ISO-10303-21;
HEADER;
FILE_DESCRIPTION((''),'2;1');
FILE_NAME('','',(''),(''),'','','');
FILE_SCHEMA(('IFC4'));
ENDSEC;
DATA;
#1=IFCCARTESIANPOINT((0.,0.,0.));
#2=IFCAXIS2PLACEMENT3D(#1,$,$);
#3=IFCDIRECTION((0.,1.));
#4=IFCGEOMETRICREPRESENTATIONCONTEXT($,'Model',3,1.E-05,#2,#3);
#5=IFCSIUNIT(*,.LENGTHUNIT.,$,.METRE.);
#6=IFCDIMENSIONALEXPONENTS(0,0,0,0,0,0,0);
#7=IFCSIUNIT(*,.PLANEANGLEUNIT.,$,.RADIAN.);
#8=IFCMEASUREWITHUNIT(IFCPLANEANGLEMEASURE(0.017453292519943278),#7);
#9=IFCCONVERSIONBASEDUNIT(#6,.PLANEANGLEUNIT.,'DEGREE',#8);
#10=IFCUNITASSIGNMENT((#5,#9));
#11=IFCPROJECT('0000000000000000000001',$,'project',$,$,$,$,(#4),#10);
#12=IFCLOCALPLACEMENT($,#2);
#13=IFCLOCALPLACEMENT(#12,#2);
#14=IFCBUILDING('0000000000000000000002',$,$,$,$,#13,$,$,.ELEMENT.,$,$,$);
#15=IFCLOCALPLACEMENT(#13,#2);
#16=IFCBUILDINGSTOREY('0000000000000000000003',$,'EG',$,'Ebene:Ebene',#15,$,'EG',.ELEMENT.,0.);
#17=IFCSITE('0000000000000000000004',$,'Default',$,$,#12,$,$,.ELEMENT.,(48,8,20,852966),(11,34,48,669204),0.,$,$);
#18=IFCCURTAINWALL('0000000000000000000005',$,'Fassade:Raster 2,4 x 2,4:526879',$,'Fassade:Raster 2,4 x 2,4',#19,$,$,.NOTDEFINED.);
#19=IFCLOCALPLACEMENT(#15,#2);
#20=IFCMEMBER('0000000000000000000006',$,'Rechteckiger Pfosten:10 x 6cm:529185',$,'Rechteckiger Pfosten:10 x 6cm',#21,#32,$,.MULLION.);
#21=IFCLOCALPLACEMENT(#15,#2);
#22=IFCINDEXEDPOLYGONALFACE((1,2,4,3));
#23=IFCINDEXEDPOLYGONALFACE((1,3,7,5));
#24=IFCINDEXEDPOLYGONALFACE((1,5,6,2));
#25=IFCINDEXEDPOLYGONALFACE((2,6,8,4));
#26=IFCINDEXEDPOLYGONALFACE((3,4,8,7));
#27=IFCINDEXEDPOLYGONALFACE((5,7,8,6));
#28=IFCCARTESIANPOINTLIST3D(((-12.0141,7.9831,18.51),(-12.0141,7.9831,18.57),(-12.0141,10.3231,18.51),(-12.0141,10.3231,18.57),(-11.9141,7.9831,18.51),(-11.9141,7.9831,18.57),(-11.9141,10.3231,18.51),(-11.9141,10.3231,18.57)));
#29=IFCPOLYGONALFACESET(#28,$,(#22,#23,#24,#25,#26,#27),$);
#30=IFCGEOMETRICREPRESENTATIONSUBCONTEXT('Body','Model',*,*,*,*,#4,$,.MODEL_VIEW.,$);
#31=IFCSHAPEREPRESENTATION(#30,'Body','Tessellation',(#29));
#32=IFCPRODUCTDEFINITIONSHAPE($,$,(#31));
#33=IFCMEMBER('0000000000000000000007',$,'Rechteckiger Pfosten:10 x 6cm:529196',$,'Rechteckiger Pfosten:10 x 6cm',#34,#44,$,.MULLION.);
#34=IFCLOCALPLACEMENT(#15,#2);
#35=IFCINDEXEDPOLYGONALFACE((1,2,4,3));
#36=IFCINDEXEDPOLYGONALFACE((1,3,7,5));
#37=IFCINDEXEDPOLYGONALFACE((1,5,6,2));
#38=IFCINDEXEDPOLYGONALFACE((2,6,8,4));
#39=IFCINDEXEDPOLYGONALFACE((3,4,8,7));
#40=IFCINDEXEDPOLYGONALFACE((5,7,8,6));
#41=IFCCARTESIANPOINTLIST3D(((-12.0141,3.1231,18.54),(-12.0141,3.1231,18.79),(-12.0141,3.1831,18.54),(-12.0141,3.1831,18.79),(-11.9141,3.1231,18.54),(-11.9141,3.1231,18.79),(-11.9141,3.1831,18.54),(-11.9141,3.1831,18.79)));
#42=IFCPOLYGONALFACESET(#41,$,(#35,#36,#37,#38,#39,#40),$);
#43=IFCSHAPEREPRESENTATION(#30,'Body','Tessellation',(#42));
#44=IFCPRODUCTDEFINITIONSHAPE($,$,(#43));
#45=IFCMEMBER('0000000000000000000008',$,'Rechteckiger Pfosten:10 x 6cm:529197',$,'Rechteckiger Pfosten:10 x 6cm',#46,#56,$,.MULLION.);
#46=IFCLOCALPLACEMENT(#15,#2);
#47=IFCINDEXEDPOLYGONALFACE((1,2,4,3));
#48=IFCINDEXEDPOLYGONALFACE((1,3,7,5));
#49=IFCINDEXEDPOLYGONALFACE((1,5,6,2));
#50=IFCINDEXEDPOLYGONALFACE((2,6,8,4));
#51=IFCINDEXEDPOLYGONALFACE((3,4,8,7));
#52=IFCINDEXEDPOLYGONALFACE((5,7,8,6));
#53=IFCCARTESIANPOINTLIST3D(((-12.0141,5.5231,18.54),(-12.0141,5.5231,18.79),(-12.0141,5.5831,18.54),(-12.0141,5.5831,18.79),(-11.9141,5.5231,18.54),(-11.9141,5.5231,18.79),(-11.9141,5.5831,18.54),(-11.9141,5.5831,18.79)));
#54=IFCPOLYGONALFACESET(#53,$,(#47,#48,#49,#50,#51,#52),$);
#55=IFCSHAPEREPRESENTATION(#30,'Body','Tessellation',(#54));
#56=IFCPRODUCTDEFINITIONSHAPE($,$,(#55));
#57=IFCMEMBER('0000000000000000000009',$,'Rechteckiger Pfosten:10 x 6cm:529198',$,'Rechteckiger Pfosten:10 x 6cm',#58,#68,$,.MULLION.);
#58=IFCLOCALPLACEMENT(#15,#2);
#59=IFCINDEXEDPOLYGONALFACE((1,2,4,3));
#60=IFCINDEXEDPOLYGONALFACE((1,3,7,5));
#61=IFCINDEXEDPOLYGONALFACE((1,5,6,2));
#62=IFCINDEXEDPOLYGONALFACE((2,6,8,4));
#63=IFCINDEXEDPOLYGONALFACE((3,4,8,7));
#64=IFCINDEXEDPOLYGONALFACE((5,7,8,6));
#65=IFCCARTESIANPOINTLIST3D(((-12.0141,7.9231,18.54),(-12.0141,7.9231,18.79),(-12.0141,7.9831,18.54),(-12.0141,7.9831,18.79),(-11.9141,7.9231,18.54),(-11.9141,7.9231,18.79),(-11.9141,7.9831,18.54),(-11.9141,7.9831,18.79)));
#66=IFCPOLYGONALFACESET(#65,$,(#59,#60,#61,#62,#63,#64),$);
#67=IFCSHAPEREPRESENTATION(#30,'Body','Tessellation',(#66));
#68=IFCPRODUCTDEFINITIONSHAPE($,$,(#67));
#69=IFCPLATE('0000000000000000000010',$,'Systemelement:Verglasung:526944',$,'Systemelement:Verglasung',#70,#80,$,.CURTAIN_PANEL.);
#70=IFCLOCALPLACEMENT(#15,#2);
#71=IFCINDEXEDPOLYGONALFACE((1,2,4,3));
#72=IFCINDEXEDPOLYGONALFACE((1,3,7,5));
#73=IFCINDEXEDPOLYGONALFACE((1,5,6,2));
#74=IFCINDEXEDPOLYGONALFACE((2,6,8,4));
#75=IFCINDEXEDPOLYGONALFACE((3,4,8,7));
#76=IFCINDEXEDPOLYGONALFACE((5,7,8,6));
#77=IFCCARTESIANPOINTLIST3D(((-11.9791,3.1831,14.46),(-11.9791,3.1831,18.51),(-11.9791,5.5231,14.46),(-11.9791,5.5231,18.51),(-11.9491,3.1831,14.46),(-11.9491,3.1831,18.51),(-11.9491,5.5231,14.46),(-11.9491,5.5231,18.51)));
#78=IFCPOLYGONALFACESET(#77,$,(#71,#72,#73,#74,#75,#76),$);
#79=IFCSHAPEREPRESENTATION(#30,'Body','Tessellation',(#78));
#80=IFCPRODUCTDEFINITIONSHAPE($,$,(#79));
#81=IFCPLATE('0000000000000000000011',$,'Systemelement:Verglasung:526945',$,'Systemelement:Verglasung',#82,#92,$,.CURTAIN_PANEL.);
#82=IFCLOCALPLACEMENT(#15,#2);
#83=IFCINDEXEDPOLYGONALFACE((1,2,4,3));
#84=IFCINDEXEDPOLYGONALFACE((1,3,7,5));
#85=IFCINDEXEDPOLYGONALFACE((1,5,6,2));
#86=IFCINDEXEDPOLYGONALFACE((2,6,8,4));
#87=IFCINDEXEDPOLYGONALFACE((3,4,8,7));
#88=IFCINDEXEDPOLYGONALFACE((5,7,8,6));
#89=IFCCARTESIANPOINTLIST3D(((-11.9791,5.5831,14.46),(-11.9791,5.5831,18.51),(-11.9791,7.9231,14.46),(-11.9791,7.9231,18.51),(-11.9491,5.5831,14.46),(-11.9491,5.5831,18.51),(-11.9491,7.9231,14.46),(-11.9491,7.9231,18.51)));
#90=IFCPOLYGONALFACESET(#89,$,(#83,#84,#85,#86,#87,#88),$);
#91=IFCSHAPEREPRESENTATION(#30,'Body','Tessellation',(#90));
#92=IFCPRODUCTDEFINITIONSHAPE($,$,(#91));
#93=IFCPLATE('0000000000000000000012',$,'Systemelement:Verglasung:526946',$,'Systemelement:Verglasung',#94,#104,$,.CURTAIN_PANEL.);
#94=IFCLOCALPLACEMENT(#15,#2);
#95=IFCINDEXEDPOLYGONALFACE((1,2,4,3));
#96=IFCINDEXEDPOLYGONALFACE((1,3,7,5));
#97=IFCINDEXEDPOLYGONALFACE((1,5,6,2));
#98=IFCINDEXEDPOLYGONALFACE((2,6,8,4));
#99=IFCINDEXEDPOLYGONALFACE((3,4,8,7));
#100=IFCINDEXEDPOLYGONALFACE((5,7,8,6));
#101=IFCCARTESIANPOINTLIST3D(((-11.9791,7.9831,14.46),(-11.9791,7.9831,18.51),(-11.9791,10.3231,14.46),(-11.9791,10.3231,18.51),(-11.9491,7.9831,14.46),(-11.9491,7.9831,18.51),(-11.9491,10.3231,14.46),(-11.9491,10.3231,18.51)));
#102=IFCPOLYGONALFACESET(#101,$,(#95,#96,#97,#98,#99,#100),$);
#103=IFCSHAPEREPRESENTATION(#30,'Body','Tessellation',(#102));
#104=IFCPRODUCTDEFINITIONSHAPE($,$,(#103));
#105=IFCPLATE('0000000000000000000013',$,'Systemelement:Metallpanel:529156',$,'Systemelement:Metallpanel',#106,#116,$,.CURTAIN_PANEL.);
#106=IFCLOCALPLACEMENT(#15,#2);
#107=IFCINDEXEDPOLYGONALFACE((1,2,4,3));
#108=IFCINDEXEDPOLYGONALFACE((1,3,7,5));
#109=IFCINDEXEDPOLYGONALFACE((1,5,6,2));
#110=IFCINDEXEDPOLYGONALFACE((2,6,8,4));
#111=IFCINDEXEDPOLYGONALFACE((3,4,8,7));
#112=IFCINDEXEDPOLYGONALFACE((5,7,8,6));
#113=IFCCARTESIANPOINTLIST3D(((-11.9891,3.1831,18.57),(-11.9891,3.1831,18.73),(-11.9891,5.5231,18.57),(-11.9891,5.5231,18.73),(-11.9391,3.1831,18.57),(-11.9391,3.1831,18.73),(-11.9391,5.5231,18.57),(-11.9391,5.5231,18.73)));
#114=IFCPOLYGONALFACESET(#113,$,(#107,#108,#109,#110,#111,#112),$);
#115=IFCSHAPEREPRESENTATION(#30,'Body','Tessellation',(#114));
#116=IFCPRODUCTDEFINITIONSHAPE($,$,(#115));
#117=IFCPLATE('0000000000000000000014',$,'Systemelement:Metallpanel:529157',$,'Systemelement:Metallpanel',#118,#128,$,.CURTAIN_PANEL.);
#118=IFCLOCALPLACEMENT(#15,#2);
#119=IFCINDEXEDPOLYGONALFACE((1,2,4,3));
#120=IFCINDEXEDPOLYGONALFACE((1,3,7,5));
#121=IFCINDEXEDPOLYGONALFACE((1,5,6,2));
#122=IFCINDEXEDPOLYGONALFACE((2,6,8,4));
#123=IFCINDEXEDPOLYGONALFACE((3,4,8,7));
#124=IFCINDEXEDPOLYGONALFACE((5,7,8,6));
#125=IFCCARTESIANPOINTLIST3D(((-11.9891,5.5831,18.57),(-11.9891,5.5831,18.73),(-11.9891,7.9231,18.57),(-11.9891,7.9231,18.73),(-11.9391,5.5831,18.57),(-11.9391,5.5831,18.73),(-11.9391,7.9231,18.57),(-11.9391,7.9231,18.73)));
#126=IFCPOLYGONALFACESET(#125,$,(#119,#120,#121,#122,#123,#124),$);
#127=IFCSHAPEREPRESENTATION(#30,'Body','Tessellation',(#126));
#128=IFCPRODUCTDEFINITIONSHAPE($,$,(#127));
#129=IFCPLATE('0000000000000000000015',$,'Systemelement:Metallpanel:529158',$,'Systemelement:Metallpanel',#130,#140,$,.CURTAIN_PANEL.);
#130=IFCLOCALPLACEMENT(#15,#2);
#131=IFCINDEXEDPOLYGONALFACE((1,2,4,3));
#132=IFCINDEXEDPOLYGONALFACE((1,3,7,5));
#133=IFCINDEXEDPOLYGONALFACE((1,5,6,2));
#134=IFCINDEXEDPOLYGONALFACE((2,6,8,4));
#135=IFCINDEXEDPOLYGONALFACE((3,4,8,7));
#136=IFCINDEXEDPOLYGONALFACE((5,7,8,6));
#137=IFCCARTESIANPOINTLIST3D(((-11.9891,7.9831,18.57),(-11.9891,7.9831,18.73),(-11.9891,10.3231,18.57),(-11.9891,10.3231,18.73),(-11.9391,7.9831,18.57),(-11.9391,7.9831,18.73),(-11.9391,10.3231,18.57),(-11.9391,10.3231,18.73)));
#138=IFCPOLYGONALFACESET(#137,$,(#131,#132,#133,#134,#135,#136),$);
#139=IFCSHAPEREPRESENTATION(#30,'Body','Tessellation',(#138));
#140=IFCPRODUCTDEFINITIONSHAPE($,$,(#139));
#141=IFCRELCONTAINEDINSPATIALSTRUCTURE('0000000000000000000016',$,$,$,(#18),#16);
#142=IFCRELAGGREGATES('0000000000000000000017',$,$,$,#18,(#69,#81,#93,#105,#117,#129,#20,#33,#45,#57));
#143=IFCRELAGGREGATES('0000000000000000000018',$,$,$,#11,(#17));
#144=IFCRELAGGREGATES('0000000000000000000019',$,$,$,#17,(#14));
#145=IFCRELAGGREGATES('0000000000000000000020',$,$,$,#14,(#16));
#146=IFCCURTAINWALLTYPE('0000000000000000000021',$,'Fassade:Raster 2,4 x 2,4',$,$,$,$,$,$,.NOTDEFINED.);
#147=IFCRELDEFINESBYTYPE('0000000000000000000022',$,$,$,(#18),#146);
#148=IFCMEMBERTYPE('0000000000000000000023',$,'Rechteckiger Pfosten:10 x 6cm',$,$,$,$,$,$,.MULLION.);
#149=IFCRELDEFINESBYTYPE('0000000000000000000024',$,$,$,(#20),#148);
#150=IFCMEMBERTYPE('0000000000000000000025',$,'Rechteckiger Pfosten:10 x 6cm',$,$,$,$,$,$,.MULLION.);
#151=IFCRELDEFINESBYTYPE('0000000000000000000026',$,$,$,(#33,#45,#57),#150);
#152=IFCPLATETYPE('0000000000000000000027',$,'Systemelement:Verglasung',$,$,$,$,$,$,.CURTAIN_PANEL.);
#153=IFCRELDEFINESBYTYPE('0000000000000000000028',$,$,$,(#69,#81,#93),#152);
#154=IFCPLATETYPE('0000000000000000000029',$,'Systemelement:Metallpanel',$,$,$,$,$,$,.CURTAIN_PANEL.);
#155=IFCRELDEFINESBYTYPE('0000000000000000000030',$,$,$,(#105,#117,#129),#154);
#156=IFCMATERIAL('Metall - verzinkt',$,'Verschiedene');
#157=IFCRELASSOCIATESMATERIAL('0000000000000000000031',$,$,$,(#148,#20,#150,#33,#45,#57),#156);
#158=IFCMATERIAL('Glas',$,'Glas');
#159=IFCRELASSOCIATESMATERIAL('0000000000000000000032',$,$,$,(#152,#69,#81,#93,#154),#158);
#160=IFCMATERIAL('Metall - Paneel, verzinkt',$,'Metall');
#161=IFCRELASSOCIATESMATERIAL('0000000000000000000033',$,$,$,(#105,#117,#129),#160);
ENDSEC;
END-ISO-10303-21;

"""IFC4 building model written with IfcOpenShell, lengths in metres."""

from ifc_helpers import new_model, entity, si_unit, converted_unit, direction, frame, origin, place, context, subcontext, project, spatial, indexed_curve, outline, extrude, source, transform, mapped, material, type_object, type_shapes, element, aggregate, save


model = new_model("IFC4")

# Units and contexts
model_context = context("Model", 3, precision=1e-05, world=origin(), true_north=direction((0.0, 1.0)))
body_context = subcontext(model_context, "Body", "Model", "MODEL_VIEW")
ifc_project = project(units=[si_unit("LENGTHUNIT", "METRE"), converted_unit("PLANEANGLEUNIT", "DEGREE", entity("IfcPlaneAngleMeasure", 0.017453292519943278), si_unit("PLANEANGLEUNIT", "RADIAN"), dimensions=[0, 0, 0, 0, 0, 0, 0])], contexts=[model_context])

# Site, building, storey
site_placement = place(None, origin())
site = spatial("IfcSite", under=ifc_project, at=site_placement, Name="Default", CompositionType="ELEMENT", RefLatitude=(48, 8, 20, 852966), RefLongitude=(11, 34, 48, 669204), RefElevation=0.0)
building_placement = place(site_placement, origin())
building = spatial("IfcBuilding", under=site, at=building_placement, CompositionType="ELEMENT")
storey_placement = place(building_placement, origin())
storey = spatial("IfcBuildingStorey", under=building, at=storey_placement, Name="EG", ObjectType="Ebene:Ebene", LongName="EG", CompositionType="ELEMENT", Elevation=0.0)

# Curtain wall, members, plates
curtain_wall_type = type_object("IfcCurtainWallType", Name="Fassade:Raster 2,4 x 2,4", PredefinedType="NOTDEFINED")
curtain_wall_placement = place(storey_placement, origin())
curtain_wall = element("IfcCurtainWall", 1, at=curtain_wall_placement, inside=storey, type_object=curtain_wall_type, Name="Fassade:Raster 2,4 x 2,4:526879", ObjectType="Fassade:Raster 2,4 x 2,4", PredefinedType="NOTDEFINED")
ifc_material_1 = material(Name="Metall - verzinkt", Category="Verschiedene")
member_type_1 = type_object("IfcMemberType", Name="Rechteckiger Pfosten:10 x 6cm", PredefinedType="MULLION", material=ifc_material_1)
shared_shape_1 = source(origin(), body_context, "Body", "SweptSolid", [
    extrude(outline(indexed_curve([(-0.03, -0.05), (0.03, -0.05), (0.03, 0.05), (-0.03, 0.05), (-0.03, -0.05)], self_intersect=False)), frame((0.0, 0.0, -2.34), z_axis=(0.0, 0.0, 1.0), x_axis=(-1.0, 0.0, 0.0)), (0.0, 0.0, 1.0), 2.34),
])
type_shapes(member_type_1, [shared_shape_1])
member_1_placement = place(curtain_wall_placement, frame((-11.9641, 10.3231, 18.54), z_axis=(0.0, 1.0, 0.0), x_axis=(0.0, 0.0, 1.0)))
member_1 = element("IfcMember", 2, at=member_1_placement, type_object=member_type_1, material=ifc_material_1, Name="Rechteckiger Pfosten:10 x 6cm:529185", ObjectType="Rechteckiger Pfosten:10 x 6cm", PredefinedType="MULLION", context=body_context, shape_type="MappedRepresentation", body=[
    mapped(shared_shape_1, transform((0.0, 0.0, 0.0), scale=1.0)),
])
member_type_2 = type_object("IfcMemberType", Name="Rechteckiger Pfosten:10 x 6cm", PredefinedType="MULLION", material=ifc_material_1)
shared_shape_2 = source(origin(), body_context, "Body", "SweptSolid", [
    extrude(outline(indexed_curve([(-0.03, -0.05), (0.03, -0.05), (0.03, 0.05), (-0.03, 0.05), (-0.03, -0.05)], self_intersect=False)), frame((0.0, 0.0, -0.25), z_axis=(0.0, 0.0, 1.0), x_axis=(-1.0, 0.0, 0.0)), (0.0, 0.0, 1.0), 0.25),
])
type_shapes(member_type_2, [shared_shape_2])
member_2_placement = place(curtain_wall_placement, frame((-11.9641, 3.1531, 18.54), z_axis=(0.0, 0.0, -1.0), x_axis=(0.0, 1.0, 0.0)))
member_2 = element("IfcMember", 3, at=member_2_placement, type_object=member_type_2, material=ifc_material_1, Name="Rechteckiger Pfosten:10 x 6cm:529196", ObjectType="Rechteckiger Pfosten:10 x 6cm", PredefinedType="MULLION", context=body_context, shape_type="MappedRepresentation", body=[
    mapped(shared_shape_2, transform((0.0, 0.0, 0.0), scale=1.0)),
])
member_3_placement = place(curtain_wall_placement, frame((-11.9641, 5.5531, 18.54), z_axis=(0.0, 0.0, -1.0), x_axis=(0.0, 1.0, 0.0)))
member_3 = element("IfcMember", 4, at=member_3_placement, type_object=member_type_2, material=ifc_material_1, Name="Rechteckiger Pfosten:10 x 6cm:529197", ObjectType="Rechteckiger Pfosten:10 x 6cm", PredefinedType="MULLION", context=body_context, shape_type="MappedRepresentation", body=[
    mapped(shared_shape_2, transform((0.0, 0.0, 0.0), scale=1.0)),
])
member_4_placement = place(curtain_wall_placement, frame((-11.9641, 7.9531, 18.54), z_axis=(0.0, 0.0, -1.0), x_axis=(0.0, 1.0, 0.0)))
member_4 = element("IfcMember", 5, at=member_4_placement, type_object=member_type_2, material=ifc_material_1, Name="Rechteckiger Pfosten:10 x 6cm:529198", ObjectType="Rechteckiger Pfosten:10 x 6cm", PredefinedType="MULLION", context=body_context, shape_type="MappedRepresentation", body=[
    mapped(shared_shape_2, transform((0.0, 0.0, 0.0), scale=1.0)),
])
ifc_material_2 = material(Name="Glas", Category="Glas")
plate_type_1 = type_object("IfcPlateType", Name="Systemelement:Verglasung", PredefinedType="CURTAIN_PANEL", material=ifc_material_2)
shared_shape_3 = source(origin(), body_context, "Body", "SweptSolid", [
    extrude(outline(indexed_curve([(-0.015, -1.17), (0.015, -1.17), (0.015, 1.17), (-0.015, 1.17), (-0.015, -1.17)], self_intersect=False)), frame((0.0, 0.0, 0.0), z_axis=(0.0, 0.0, 1.0), x_axis=(0.0, 1.0, 0.0)), (0.0, 0.0, 1.0), 4.05),
])
type_shapes(plate_type_1, [shared_shape_3])
plate_1_placement = place(curtain_wall_placement, frame((-11.9641, 4.3531, 14.46), z_axis=(0.0, 0.0, 1.0), x_axis=(0.0, 1.0, 0.0)))
plate_1 = element("IfcPlate", 6, at=plate_1_placement, type_object=plate_type_1, material=ifc_material_2, Name="Systemelement:Verglasung:526944", ObjectType="Systemelement:Verglasung", PredefinedType="CURTAIN_PANEL", context=body_context, shape_type="MappedRepresentation", body=[
    mapped(shared_shape_3, transform((0.0, 0.0, 0.0), scale=1.0)),
])
plate_2_placement = place(curtain_wall_placement, frame((-11.9641, 6.7531, 14.46), z_axis=(0.0, 0.0, 1.0), x_axis=(0.0, 1.0, 0.0)))
plate_2 = element("IfcPlate", 7, at=plate_2_placement, type_object=plate_type_1, material=ifc_material_2, Name="Systemelement:Verglasung:526945", ObjectType="Systemelement:Verglasung", PredefinedType="CURTAIN_PANEL", context=body_context, shape_type="MappedRepresentation", body=[
    mapped(shared_shape_3, transform((0.0, 0.0, 0.0), scale=1.0)),
])
plate_3_placement = place(curtain_wall_placement, frame((-11.9641, 9.1531, 14.46), z_axis=(0.0, 0.0, 1.0), x_axis=(0.0, 1.0, 0.0)))
plate_3 = element("IfcPlate", 8, at=plate_3_placement, type_object=plate_type_1, material=ifc_material_2, Name="Systemelement:Verglasung:526946", ObjectType="Systemelement:Verglasung", PredefinedType="CURTAIN_PANEL", context=body_context, shape_type="MappedRepresentation", body=[
    mapped(shared_shape_3, transform((0.0, 0.0, 0.0), scale=1.0)),
])
ifc_material_3 = material(Name="Metall - Paneel, verzinkt", Category="Metall")
plate_type_2 = type_object("IfcPlateType", Name="Systemelement:Metallpanel", PredefinedType="CURTAIN_PANEL", material=ifc_material_2)
shared_shape_4 = source(origin(), body_context, "Body", "SweptSolid", [
    extrude(outline(indexed_curve([(-0.025, -1.17), (0.025, -1.17), (0.025, 1.17), (-0.025, 1.17), (-0.025, -1.17)], self_intersect=False)), frame((0.0, 0.0, 0.0), z_axis=(0.0, 0.0, 1.0), x_axis=(0.0, 1.0, 0.0)), (0.0, 0.0, 1.0), 0.16),
])
type_shapes(plate_type_2, [shared_shape_4])
plate_4_placement = place(curtain_wall_placement, frame((-11.9641, 4.3531, 18.57), z_axis=(0.0, 0.0, 1.0), x_axis=(0.0, 1.0, 0.0)))
plate_4 = element("IfcPlate", 9, at=plate_4_placement, type_object=plate_type_2, material=ifc_material_3, Name="Systemelement:Metallpanel:529156", ObjectType="Systemelement:Metallpanel", PredefinedType="CURTAIN_PANEL", context=body_context, shape_type="MappedRepresentation", body=[
    mapped(shared_shape_4, transform((0.0, 0.0, 0.0), scale=1.0)),
])
plate_5_placement = place(curtain_wall_placement, frame((-11.9641, 6.7531, 18.57), z_axis=(0.0, 0.0, 1.0), x_axis=(0.0, 1.0, 0.0)))
plate_5 = element("IfcPlate", 10, at=plate_5_placement, type_object=plate_type_2, material=ifc_material_3, Name="Systemelement:Metallpanel:529157", ObjectType="Systemelement:Metallpanel", PredefinedType="CURTAIN_PANEL", context=body_context, shape_type="MappedRepresentation", body=[
    mapped(shared_shape_4, transform((0.0, 0.0, 0.0), scale=1.0)),
])
plate_6_placement = place(curtain_wall_placement, frame((-11.9641, 9.1531, 18.57), z_axis=(0.0, 0.0, 1.0), x_axis=(0.0, 1.0, 0.0)))
plate_6 = element("IfcPlate", 11, at=plate_6_placement, type_object=plate_type_2, material=ifc_material_3, Name="Systemelement:Metallpanel:529158", ObjectType="Systemelement:Metallpanel", PredefinedType="CURTAIN_PANEL", context=body_context, shape_type="MappedRepresentation", body=[
    mapped(shared_shape_4, transform((0.0, 0.0, 0.0), scale=1.0)),
])
aggregate(curtain_wall, [plate_1, plate_2, plate_3, plate_4, plate_5, plate_6, member_1, member_2, member_3, member_4])

save(model, "model.ifc")
